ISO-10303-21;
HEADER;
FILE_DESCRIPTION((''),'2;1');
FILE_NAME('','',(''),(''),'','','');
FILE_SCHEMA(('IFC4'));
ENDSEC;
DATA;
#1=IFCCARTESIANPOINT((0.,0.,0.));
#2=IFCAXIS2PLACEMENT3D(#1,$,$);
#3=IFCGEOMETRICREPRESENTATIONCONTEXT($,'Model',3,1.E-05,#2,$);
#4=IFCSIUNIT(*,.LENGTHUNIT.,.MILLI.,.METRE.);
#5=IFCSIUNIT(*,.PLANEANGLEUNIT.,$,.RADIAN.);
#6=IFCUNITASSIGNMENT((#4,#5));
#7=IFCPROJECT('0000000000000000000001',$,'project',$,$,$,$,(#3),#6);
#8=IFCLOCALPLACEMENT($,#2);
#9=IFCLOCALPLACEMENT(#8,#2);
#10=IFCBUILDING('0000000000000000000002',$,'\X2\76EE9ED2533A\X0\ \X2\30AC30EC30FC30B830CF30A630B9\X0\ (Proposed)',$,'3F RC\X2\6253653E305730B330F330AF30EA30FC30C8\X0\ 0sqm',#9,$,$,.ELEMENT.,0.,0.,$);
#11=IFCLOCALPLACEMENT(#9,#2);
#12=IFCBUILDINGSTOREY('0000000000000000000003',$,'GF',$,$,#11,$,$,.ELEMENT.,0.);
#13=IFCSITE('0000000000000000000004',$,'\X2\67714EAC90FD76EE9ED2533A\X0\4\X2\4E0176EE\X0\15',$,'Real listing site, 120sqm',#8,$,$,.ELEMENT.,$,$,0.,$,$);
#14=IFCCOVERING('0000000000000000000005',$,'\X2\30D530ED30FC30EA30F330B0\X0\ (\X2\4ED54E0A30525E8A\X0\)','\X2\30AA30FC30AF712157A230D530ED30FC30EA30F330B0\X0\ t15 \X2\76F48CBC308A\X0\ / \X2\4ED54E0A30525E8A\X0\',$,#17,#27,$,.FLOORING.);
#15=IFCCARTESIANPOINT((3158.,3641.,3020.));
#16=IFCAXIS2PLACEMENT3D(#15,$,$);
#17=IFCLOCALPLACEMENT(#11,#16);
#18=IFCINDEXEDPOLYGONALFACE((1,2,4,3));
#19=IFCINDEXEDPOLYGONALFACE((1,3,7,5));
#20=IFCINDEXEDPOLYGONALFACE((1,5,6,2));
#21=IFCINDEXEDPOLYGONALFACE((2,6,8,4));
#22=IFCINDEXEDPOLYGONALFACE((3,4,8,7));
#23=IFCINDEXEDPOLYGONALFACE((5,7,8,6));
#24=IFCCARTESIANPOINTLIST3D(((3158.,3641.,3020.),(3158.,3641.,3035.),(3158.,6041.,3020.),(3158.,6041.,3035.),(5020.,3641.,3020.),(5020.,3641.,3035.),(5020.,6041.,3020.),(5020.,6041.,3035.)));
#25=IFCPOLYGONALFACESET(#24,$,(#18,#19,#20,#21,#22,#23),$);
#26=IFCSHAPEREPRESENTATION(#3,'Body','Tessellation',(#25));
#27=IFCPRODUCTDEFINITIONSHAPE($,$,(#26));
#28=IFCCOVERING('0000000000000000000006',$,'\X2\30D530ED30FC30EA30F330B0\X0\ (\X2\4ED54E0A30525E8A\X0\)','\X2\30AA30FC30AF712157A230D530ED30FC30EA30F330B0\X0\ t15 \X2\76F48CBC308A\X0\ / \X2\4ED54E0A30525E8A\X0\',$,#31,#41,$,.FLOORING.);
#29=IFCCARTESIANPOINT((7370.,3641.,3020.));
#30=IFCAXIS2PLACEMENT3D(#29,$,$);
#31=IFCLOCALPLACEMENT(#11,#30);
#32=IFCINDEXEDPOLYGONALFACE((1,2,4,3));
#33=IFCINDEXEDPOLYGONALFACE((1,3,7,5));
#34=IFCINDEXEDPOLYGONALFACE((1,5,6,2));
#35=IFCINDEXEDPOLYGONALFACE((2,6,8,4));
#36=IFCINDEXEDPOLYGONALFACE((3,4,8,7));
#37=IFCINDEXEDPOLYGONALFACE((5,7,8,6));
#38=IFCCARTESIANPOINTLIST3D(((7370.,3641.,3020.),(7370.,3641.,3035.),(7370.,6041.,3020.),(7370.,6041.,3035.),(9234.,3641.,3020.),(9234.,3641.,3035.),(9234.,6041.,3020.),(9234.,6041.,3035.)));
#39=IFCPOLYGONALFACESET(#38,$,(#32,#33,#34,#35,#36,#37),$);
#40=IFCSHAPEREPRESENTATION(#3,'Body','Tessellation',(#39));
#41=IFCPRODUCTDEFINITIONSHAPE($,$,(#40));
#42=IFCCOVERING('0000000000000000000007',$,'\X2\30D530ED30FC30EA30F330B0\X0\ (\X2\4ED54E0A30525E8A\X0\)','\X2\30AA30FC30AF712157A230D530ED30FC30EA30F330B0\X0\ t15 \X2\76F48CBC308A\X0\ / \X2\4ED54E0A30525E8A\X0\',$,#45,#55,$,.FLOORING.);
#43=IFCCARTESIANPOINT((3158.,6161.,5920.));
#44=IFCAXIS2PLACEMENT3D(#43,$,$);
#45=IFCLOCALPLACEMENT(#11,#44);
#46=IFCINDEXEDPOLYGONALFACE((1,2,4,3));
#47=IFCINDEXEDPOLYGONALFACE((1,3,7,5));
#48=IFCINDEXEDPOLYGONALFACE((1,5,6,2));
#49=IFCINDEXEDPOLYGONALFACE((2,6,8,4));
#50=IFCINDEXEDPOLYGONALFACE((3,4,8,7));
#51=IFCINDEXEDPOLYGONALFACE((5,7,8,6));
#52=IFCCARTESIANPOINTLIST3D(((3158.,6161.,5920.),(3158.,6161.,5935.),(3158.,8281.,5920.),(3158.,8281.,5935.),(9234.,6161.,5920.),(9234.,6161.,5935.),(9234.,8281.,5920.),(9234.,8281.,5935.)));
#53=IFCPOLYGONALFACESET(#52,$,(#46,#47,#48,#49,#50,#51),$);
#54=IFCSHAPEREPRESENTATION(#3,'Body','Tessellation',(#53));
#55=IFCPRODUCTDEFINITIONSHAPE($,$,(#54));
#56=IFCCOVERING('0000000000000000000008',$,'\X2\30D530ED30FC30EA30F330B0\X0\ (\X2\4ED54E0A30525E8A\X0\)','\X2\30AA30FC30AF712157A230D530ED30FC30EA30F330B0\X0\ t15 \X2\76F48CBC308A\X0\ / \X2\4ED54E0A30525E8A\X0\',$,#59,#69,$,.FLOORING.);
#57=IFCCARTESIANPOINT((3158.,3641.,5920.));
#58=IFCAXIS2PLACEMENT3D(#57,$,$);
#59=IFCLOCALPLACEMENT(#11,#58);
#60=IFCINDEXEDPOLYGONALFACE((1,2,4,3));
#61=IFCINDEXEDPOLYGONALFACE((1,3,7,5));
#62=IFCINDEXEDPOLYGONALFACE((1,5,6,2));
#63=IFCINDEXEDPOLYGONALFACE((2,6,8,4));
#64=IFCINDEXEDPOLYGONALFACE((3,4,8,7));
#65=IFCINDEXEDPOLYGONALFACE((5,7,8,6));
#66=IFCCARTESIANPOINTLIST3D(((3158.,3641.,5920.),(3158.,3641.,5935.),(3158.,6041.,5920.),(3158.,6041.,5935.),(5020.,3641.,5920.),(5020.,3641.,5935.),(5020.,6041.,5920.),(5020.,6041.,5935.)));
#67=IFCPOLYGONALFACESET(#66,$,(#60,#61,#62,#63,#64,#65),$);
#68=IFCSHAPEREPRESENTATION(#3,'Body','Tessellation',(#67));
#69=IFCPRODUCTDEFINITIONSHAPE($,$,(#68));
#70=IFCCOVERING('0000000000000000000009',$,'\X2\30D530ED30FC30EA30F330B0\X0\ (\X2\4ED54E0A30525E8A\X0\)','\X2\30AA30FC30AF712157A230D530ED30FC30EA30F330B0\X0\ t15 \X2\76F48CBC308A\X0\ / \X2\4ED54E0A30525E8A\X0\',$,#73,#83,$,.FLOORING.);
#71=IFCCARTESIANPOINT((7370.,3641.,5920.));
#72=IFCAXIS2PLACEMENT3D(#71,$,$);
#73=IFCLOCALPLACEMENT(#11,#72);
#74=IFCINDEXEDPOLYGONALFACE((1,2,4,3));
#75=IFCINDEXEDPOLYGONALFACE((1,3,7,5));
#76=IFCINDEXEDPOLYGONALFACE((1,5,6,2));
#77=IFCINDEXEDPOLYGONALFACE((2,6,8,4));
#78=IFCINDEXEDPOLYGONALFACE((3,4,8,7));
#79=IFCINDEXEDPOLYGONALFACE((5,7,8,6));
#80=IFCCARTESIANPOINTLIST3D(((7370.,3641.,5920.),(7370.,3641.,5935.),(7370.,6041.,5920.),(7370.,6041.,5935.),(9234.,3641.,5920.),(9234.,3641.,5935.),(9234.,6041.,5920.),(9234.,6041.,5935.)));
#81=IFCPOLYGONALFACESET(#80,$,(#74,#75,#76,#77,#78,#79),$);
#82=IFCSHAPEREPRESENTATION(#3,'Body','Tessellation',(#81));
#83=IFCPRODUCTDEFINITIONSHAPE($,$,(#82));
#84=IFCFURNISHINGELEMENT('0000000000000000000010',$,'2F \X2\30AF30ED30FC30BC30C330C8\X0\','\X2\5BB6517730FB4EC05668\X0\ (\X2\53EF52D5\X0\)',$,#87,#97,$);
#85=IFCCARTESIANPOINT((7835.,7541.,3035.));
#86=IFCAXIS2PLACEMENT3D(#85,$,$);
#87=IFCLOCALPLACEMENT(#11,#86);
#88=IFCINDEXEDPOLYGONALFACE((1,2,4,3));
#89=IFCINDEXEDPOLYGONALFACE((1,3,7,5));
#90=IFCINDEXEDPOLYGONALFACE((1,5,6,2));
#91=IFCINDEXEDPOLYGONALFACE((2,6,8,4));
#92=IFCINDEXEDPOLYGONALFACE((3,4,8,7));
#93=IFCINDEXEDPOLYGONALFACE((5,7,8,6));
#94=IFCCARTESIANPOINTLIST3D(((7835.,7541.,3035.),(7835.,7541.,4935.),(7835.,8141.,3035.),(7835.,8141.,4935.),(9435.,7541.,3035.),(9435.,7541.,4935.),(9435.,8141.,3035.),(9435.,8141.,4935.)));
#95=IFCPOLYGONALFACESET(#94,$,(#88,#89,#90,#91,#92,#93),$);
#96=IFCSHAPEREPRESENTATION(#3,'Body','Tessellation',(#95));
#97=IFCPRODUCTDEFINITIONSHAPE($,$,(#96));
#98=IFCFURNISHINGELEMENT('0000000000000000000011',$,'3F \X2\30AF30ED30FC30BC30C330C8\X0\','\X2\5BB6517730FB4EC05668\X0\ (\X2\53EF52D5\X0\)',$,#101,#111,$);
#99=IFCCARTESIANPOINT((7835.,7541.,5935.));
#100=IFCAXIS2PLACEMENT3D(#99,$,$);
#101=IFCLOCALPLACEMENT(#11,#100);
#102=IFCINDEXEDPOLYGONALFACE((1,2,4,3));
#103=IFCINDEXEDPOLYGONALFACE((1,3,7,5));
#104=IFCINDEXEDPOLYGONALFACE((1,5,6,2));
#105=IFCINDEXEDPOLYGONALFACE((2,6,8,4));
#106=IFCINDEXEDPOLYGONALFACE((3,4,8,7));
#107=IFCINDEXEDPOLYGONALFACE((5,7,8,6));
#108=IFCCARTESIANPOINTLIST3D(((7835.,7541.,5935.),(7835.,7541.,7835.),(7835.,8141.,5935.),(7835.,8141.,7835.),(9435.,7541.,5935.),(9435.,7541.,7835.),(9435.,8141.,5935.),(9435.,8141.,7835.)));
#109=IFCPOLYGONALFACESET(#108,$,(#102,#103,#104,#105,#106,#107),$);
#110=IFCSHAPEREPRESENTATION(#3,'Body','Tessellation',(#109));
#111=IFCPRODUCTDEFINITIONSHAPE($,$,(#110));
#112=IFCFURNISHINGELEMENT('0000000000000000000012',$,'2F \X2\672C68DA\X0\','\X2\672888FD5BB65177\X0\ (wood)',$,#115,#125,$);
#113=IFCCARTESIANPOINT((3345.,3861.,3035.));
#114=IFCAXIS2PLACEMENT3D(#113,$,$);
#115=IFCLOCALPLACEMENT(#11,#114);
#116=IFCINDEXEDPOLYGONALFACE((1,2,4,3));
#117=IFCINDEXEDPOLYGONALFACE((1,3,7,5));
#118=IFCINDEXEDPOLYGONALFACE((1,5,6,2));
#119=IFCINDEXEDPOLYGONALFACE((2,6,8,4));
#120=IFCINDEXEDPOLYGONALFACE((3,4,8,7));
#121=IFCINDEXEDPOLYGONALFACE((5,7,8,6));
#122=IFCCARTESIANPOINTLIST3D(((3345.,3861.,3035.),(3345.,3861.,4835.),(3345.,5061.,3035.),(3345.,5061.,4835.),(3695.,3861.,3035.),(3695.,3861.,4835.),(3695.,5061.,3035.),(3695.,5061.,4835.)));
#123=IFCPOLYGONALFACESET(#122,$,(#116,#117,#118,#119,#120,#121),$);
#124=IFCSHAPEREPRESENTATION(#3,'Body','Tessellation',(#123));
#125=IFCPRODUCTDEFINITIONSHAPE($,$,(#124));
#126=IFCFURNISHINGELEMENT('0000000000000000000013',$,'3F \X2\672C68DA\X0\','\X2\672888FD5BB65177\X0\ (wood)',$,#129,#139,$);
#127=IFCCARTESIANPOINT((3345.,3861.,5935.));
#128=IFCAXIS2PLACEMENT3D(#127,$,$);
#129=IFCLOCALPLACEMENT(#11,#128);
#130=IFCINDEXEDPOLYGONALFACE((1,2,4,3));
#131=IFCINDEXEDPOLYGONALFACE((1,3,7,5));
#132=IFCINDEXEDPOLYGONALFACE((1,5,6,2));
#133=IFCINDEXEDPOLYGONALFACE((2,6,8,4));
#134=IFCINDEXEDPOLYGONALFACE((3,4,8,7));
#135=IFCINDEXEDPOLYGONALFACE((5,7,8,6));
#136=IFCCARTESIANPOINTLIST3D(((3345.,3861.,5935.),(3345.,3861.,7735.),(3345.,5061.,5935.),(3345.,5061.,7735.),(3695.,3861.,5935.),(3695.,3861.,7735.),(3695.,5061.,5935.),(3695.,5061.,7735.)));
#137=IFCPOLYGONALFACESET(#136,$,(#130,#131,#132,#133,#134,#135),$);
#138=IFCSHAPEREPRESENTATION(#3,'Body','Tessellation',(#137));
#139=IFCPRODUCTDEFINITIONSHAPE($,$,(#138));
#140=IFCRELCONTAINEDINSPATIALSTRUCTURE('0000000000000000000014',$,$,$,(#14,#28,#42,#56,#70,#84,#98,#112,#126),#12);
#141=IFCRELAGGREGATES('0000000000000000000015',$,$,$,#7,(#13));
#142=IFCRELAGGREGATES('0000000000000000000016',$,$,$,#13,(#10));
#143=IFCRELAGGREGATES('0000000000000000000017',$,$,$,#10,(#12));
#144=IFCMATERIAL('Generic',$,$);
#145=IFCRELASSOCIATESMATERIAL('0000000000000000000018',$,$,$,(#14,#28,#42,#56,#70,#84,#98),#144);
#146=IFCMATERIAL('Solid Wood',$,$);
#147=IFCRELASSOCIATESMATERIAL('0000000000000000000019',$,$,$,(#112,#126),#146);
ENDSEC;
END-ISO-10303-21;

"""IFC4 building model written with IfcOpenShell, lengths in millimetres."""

from ifc_helpers import new_model, si_unit, frame, frame_2d, origin, place, context, project, spatial, rectangle, extrude, material, element, save


model = new_model("IFC4")

# Units and contexts
model_context = context("Model", 3, precision=1e-05, world=origin())
ifc_project = project(units=[si_unit("LENGTHUNIT", "METRE", prefix="MILLI"), si_unit("PLANEANGLEUNIT", "RADIAN")], contexts=[model_context])

# Site, building, storey
site_placement = place(None, origin())
site = spatial("IfcSite", under=ifc_project, at=site_placement, Name="東京都目黒区4丁目15", ObjectType="Real listing site, 120sqm", CompositionType="ELEMENT", RefElevation=0.0)
building_placement = place(site_placement, origin())
building = spatial("IfcBuilding", under=site, at=building_placement, Name="目黒区 ガレージハウス (Proposed)", ObjectType="3F RC打放しコンクリート 0sqm", CompositionType="ELEMENT", ElevationOfRefHeight=0.0, ElevationOfTerrain=0.0)
storey_placement = place(building_placement, origin())
storey = spatial("IfcBuildingStorey", under=building, at=storey_placement, Name="GF", CompositionType="ELEMENT", Elevation=0.0)

# Shared definitions
ifc_material_1 = material(Name="Solid Wood")

# Coverings
ifc_material_2 = material(Name="Generic")
covering_1_placement = place(storey_placement, frame((3158.0, 3641.0, 3020.0)))
element("IfcCovering", 1, at=covering_1_placement, inside=storey, material=ifc_material_2, Name="フローリング (仕上げ床)", Description="オーク無垢フローリング t15 直貼り / 仕上げ床", PredefinedType="FLOORING", context=model_context, shape_type="SweptSolid", body=[
    extrude(rectangle(XDim=1862.0, YDim=2400.0, at=frame_2d((931.0, 1200.0))), frame((3158.0, 3641.0, 3020.0)), (0.0, 0.0, 1.0), 15.0),
])
covering_2_placement = place(storey_placement, frame((7370.0, 3641.0, 3020.0)))
element("IfcCovering", 2, at=covering_2_placement, inside=storey, material=ifc_material_2, Name="フローリング (仕上げ床)", Description="オーク無垢フローリング t15 直貼り / 仕上げ床", PredefinedType="FLOORING", context=model_context, shape_type="SweptSolid", body=[
    extrude(rectangle(XDim=1864.0, YDim=2400.0, at=frame_2d((932.0, 1200.0))), frame((7370.0, 3641.0, 3020.0)), (0.0, 0.0, 1.0), 15.0),
])
covering_3_placement = place(storey_placement, frame((3158.0, 6161.0, 5920.0)))
element("IfcCovering", 3, at=covering_3_placement, inside=storey, material=ifc_material_2, Name="フローリング (仕上げ床)", Description="オーク無垢フローリング t15 直貼り / 仕上げ床", PredefinedType="FLOORING", context=model_context, shape_type="SweptSolid", body=[
    extrude(rectangle(XDim=6076.0, YDim=2120.0, at=frame_2d((3038.0, 1060.0))), frame((3158.0, 6161.0, 5920.0)), (0.0, 0.0, 1.0), 15.0),
])
covering_4_placement = place(storey_placement, frame((3158.0, 3641.0, 5920.0)))
element("IfcCovering", 4, at=covering_4_placement, inside=storey, material=ifc_material_2, Name="フローリング (仕上げ床)", Description="オーク無垢フローリング t15 直貼り / 仕上げ床", PredefinedType="FLOORING", context=model_context, shape_type="SweptSolid", body=[
    extrude(rectangle(XDim=1862.0, YDim=2400.0, at=frame_2d((931.0, 1200.0))), frame((3158.0, 3641.0, 5920.0)), (0.0, 0.0, 1.0), 15.0),
])
covering_5_placement = place(storey_placement, frame((7370.0, 3641.0, 5920.0)))
element("IfcCovering", 5, at=covering_5_placement, inside=storey, material=ifc_material_2, Name="フローリング (仕上げ床)", Description="オーク無垢フローリング t15 直貼り / 仕上げ床", PredefinedType="FLOORING", context=model_context, shape_type="SweptSolid", body=[
    extrude(rectangle(XDim=1864.0, YDim=2400.0, at=frame_2d((932.0, 1200.0))), frame((7370.0, 3641.0, 5920.0)), (0.0, 0.0, 1.0), 15.0),
])

# Furnishing elements
furnishing_1_placement = place(storey_placement, frame((7835.0, 7541.0, 3035.0)))
element("IfcFurnishingElement", 6, at=furnishing_1_placement, inside=storey, material=ifc_material_2, Name="2F クローゼット", Description="家具・什器 (可動)", context=model_context, shape_type="SweptSolid", body=[
    extrude(rectangle(XDim=1600.0, YDim=600.0, at=frame_2d((800.0, 300.0))), frame((7835.0, 7541.0, 3035.0)), (0.0, 0.0, 1.0), 1900.0),
])
furnishing_2_placement = place(storey_placement, frame((7835.0, 7541.0, 5935.0)))
element("IfcFurnishingElement", 7, at=furnishing_2_placement, inside=storey, material=ifc_material_2, Name="3F クローゼット", Description="家具・什器 (可動)", context=model_context, shape_type="SweptSolid", body=[
    extrude(rectangle(XDim=1600.0, YDim=600.0, at=frame_2d((800.0, 300.0))), frame((7835.0, 7541.0, 5935.0)), (0.0, 0.0, 1.0), 1900.0),
])
furnishing_3_placement = place(storey_placement, frame((3345.0, 3861.0, 3035.0)))
element("IfcFurnishingElement", 8, at=furnishing_3_placement, inside=storey, material=ifc_material_1, Name="2F 本棚", Description="木製家具 (wood)", context=model_context, shape_type="SweptSolid", body=[
    extrude(rectangle(XDim=350.0, YDim=1200.0, at=frame_2d((175.0, 600.0))), frame((3345.0, 3861.0, 3035.0)), (0.0, 0.0, 1.0), 1800.0),
])
furnishing_4_placement = place(storey_placement, frame((3345.0, 3861.0, 5935.0)))
element("IfcFurnishingElement", 9, at=furnishing_4_placement, inside=storey, material=ifc_material_1, Name="3F 本棚", Description="木製家具 (wood)", context=model_context, shape_type="SweptSolid", body=[
    extrude(rectangle(XDim=350.0, YDim=1200.0, at=frame_2d((175.0, 600.0))), frame((3345.0, 3861.0, 5935.0)), (0.0, 0.0, 1.0), 1800.0),
])

save(model, "model.ifc")
